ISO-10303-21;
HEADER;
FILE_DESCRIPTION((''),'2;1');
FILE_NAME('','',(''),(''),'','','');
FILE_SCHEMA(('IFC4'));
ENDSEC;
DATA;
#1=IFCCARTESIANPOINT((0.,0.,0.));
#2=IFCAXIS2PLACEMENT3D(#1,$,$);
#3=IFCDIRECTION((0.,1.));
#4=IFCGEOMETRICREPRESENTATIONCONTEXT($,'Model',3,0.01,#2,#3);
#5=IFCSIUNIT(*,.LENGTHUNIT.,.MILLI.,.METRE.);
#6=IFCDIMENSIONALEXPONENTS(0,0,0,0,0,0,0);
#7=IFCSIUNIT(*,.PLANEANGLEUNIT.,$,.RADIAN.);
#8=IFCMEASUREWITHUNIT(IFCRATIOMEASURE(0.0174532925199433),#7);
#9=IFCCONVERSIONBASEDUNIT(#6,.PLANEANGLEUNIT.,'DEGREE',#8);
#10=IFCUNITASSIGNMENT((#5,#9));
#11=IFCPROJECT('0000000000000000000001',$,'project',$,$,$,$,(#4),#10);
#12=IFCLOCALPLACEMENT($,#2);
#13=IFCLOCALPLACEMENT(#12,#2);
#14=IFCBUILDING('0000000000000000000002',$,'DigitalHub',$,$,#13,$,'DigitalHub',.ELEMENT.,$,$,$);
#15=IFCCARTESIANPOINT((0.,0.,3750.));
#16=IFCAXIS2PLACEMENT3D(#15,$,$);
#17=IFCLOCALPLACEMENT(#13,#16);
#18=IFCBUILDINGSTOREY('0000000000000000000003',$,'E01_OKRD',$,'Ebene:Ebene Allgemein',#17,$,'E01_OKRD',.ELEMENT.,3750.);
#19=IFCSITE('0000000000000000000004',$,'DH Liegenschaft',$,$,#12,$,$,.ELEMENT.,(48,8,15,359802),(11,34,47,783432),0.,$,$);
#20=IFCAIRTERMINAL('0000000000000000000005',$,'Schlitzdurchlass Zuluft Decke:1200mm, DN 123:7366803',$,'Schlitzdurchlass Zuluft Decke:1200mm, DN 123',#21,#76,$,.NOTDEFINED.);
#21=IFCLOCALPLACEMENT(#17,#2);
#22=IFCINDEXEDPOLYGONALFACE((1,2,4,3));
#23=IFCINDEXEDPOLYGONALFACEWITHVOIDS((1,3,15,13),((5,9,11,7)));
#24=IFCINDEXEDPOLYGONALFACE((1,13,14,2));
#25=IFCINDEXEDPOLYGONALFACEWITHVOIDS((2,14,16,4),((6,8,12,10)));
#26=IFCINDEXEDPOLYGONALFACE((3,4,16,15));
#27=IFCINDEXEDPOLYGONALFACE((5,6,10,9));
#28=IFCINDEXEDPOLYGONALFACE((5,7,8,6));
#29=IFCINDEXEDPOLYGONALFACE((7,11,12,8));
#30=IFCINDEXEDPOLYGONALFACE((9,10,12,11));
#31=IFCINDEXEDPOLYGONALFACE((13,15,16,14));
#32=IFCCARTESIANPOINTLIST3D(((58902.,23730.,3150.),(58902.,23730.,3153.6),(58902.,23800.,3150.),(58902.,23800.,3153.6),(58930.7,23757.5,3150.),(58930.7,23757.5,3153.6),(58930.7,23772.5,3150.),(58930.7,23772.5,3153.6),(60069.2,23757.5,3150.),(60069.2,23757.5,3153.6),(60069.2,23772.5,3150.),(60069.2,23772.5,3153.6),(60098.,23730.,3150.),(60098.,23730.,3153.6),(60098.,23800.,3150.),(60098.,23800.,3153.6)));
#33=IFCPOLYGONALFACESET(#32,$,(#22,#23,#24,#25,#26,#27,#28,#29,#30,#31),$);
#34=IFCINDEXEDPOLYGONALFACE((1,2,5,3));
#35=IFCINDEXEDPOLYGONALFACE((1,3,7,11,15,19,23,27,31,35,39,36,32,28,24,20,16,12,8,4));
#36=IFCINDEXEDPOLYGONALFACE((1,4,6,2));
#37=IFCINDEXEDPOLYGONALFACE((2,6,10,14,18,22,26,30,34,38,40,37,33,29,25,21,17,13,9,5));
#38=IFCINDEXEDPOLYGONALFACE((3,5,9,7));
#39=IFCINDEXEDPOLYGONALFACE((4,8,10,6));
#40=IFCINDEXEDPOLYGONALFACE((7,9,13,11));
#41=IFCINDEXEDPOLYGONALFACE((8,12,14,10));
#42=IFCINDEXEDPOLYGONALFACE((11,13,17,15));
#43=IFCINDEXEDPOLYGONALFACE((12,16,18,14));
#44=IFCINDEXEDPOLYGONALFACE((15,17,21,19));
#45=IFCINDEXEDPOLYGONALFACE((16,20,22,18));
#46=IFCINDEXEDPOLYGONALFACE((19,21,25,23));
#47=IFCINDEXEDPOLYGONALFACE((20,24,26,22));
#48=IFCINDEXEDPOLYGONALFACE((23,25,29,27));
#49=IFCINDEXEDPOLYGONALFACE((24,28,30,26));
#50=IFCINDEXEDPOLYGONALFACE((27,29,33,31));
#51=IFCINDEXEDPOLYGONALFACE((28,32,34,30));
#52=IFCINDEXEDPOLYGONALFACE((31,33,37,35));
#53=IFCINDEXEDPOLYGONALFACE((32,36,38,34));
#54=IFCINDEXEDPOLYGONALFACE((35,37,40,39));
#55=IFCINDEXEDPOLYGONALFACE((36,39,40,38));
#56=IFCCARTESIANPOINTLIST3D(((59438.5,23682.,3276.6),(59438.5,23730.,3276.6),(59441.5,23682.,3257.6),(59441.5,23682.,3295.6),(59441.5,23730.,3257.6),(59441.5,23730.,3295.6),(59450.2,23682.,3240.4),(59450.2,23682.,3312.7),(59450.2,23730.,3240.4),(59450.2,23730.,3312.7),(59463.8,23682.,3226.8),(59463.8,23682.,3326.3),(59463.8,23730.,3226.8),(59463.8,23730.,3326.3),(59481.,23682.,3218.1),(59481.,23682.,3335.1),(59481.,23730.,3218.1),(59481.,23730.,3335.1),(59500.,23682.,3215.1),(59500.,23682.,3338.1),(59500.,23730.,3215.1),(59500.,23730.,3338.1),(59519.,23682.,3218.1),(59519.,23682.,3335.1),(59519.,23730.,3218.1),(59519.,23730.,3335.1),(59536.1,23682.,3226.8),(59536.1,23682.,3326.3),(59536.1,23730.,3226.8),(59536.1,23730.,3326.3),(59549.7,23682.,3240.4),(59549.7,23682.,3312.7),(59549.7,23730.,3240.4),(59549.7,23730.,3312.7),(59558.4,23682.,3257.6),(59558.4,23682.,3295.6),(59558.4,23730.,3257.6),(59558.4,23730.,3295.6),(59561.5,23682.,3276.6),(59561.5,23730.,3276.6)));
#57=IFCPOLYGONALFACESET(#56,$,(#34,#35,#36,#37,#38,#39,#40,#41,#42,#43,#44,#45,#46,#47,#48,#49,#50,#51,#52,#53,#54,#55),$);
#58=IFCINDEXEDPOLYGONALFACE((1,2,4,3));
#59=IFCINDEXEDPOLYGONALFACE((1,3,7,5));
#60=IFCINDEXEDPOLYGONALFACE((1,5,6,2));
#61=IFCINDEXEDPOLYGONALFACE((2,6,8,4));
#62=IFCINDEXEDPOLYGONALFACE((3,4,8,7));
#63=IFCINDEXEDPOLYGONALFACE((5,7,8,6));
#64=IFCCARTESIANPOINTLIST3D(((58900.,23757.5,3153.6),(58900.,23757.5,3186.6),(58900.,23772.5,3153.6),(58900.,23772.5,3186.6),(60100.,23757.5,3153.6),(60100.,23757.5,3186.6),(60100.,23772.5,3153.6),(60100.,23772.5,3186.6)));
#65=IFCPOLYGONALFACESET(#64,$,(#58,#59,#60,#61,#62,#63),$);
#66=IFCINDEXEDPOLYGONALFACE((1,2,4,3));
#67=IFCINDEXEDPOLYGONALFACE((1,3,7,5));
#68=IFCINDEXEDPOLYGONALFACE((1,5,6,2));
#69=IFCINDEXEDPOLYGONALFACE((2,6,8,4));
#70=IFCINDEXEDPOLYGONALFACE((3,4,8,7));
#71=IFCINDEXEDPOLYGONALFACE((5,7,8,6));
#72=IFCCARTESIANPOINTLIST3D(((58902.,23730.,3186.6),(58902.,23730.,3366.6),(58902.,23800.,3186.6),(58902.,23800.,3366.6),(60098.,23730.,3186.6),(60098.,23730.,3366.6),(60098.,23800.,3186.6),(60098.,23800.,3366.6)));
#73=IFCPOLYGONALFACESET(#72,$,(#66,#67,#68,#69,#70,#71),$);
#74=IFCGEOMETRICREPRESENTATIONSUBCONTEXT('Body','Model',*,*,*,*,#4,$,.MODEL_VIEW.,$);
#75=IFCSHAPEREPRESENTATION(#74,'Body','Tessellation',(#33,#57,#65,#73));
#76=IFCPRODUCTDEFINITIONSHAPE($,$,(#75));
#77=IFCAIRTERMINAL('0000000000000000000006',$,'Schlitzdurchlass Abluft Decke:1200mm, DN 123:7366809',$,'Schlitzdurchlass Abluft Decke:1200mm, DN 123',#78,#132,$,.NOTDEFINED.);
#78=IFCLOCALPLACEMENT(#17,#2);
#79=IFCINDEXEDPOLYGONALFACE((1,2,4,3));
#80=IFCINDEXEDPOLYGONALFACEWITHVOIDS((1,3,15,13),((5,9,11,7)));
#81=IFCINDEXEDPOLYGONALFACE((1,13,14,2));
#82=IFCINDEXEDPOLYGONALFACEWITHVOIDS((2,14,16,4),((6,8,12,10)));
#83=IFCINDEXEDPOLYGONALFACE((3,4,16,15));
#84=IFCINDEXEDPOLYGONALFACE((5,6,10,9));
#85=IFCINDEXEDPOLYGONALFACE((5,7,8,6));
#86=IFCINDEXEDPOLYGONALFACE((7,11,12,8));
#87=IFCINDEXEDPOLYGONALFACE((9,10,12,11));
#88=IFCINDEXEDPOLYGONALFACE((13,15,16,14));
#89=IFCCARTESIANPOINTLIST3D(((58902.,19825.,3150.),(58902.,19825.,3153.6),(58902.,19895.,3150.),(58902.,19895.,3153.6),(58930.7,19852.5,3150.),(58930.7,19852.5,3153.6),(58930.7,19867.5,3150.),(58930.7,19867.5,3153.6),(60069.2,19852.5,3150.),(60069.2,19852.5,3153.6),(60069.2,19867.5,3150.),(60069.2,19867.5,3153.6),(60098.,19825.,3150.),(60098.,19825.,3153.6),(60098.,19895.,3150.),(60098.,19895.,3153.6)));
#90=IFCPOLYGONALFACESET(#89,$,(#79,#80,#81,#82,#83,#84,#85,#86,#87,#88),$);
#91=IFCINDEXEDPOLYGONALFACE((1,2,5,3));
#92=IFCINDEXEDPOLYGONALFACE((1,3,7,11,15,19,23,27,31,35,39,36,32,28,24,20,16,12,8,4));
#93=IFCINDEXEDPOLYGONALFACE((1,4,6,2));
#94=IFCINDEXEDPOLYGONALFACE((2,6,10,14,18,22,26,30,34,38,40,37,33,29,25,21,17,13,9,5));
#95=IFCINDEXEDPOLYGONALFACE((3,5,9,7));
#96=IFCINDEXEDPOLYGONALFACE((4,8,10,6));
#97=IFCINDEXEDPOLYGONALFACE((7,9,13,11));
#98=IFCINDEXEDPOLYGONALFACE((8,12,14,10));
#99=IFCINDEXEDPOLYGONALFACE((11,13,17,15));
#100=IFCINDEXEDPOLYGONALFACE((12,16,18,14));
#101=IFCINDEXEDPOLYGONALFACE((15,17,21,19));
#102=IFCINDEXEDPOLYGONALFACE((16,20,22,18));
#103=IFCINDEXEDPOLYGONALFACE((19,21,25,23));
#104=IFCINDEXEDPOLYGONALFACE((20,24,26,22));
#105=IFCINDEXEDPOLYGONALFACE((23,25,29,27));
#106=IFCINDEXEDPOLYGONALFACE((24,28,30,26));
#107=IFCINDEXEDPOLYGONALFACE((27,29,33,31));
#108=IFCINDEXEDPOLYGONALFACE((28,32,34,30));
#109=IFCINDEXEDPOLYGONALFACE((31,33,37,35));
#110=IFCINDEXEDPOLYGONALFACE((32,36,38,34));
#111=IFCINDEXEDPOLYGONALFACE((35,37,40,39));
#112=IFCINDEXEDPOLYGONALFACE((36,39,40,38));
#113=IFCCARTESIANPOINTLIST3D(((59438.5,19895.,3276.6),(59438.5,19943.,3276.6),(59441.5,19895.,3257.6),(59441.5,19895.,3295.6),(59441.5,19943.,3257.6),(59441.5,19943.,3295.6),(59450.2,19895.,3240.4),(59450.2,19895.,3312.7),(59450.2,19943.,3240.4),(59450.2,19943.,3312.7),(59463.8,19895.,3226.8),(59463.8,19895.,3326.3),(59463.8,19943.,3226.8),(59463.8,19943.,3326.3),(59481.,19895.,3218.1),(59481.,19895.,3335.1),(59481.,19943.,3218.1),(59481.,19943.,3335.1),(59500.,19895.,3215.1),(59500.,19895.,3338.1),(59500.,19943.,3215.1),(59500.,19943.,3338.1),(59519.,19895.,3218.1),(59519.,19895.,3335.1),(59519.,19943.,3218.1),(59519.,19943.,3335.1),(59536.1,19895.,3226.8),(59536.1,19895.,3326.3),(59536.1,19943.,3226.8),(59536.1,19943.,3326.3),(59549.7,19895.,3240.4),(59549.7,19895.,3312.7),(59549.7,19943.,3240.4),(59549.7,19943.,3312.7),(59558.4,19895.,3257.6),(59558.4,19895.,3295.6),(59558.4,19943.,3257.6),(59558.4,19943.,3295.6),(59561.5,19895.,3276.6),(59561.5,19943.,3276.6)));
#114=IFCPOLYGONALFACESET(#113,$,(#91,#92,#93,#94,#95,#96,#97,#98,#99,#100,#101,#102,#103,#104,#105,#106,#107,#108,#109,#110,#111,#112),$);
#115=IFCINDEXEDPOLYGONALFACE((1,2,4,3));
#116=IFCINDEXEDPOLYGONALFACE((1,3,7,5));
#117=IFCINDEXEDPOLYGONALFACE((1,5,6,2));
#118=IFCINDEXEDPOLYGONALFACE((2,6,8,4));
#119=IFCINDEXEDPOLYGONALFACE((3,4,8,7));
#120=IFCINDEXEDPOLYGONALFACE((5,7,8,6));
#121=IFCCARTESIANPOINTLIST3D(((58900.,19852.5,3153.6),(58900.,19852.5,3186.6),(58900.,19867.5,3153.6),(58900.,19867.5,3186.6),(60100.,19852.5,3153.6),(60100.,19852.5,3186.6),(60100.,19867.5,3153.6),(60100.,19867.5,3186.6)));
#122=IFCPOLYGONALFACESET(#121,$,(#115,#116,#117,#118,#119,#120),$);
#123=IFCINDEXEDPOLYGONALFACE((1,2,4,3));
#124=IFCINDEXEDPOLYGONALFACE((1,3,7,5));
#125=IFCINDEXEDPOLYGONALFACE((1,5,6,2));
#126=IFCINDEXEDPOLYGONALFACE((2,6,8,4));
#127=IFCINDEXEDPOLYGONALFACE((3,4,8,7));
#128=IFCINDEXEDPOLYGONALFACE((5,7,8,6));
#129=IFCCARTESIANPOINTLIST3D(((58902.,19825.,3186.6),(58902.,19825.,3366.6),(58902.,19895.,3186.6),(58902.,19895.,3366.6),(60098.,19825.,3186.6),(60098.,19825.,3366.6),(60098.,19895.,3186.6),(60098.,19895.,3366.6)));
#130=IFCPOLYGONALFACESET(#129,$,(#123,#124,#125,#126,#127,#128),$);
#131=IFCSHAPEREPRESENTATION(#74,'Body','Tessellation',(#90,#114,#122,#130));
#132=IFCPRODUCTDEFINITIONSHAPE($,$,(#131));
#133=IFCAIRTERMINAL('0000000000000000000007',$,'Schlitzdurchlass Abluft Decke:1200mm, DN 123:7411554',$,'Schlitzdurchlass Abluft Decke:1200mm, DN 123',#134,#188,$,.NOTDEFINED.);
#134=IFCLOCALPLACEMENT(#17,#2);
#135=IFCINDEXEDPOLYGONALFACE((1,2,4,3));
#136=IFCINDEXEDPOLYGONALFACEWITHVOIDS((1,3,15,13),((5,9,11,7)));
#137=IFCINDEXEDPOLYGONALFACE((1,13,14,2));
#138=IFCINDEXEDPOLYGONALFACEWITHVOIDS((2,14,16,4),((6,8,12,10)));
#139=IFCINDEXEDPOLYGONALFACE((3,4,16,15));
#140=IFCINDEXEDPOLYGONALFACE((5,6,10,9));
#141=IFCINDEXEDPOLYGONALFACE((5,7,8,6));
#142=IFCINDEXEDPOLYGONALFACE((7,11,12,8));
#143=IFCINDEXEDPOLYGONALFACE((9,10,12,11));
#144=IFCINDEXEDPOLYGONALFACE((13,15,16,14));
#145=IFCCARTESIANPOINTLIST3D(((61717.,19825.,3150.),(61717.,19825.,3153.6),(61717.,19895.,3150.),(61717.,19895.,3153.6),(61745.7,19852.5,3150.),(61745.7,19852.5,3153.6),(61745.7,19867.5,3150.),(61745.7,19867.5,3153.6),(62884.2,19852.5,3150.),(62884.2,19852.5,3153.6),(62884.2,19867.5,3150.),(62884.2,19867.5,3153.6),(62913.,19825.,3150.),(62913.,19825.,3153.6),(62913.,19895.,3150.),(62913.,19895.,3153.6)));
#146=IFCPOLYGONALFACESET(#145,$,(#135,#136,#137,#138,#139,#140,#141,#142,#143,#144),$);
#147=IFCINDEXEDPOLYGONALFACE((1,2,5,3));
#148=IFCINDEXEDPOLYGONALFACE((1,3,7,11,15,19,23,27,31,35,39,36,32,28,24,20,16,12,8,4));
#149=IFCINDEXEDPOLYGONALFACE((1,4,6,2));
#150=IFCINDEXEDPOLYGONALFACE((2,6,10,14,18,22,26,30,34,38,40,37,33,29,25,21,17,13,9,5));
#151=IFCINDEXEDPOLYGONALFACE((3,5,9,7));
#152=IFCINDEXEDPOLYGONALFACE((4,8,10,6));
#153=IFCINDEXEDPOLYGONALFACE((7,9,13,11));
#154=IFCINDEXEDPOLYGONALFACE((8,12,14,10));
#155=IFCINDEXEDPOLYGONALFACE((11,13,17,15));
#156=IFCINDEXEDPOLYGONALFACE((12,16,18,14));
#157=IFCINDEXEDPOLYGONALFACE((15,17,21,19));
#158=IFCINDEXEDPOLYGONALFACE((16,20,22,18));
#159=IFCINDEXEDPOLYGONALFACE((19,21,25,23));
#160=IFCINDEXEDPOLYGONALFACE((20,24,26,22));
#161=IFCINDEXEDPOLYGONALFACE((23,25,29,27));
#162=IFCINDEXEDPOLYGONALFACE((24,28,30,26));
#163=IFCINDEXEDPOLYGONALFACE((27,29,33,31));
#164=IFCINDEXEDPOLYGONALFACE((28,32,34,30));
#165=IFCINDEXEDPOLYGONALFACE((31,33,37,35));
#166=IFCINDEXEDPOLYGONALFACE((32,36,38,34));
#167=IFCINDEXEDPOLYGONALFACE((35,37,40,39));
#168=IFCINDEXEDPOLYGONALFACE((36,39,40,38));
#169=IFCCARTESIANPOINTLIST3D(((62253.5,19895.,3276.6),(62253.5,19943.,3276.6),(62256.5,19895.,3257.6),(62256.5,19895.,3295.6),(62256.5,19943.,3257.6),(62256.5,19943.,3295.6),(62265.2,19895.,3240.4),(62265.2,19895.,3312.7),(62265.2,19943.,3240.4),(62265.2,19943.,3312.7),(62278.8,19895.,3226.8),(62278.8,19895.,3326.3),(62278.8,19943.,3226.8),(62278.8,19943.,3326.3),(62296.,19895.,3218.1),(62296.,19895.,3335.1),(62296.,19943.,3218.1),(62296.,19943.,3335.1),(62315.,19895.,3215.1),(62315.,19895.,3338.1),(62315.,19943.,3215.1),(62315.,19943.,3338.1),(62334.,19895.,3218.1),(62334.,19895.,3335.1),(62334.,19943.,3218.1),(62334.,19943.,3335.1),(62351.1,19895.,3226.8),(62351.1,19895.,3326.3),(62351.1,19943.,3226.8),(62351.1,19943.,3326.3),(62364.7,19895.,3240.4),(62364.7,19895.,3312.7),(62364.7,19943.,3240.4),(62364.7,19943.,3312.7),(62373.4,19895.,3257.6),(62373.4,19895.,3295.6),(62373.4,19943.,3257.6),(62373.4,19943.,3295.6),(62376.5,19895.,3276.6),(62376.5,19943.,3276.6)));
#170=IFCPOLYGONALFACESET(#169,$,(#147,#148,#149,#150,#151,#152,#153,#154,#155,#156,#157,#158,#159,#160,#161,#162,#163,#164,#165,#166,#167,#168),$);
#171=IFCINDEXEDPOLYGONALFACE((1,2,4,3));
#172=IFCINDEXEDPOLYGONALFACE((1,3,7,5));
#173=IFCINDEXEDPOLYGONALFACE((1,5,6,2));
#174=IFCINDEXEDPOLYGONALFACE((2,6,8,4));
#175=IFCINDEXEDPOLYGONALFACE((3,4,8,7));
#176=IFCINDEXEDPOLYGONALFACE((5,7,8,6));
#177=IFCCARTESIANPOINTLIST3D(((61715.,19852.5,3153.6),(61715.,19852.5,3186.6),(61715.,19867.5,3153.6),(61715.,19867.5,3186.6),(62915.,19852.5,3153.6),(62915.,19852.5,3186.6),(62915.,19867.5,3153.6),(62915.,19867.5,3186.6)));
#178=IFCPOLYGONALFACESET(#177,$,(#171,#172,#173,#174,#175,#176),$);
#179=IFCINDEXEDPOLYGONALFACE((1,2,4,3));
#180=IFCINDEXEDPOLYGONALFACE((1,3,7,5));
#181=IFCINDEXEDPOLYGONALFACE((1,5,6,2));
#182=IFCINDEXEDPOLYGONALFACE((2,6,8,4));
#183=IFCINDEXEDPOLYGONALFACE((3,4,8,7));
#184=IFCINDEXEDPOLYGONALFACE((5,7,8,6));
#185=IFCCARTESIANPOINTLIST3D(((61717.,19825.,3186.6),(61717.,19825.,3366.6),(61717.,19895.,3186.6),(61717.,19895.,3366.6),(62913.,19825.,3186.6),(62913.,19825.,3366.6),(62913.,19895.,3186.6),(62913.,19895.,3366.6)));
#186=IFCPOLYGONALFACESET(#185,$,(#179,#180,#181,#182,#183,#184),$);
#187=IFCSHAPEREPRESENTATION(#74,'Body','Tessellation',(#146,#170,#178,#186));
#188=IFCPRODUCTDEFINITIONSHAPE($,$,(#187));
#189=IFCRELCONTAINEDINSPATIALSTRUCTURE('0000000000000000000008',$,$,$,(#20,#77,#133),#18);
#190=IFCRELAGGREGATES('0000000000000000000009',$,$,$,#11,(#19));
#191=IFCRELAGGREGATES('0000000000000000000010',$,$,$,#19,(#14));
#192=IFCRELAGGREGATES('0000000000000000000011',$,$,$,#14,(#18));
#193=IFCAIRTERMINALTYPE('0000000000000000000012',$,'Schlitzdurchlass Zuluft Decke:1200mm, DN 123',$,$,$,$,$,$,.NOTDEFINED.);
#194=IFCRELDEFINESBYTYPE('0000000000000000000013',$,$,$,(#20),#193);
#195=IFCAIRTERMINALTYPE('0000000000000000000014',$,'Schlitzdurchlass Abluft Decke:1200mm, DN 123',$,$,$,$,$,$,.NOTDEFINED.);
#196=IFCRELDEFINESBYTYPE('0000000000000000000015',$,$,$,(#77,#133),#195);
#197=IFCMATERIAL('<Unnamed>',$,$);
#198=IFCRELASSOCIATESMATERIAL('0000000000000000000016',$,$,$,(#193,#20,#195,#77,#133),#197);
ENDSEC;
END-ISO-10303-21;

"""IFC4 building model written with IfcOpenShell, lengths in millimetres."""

from ifc_helpers import new_model, entity, si_unit, converted_unit, direction, frame, origin, place, context, subcontext, project, spatial, indexed_curve, outline, extrude, source, transform, mapped, material, type_object, type_shapes, element, save


model = new_model("IFC4")

# Units and contexts
model_context = context("Model", 3, precision=0.01, world=origin(), true_north=direction((0.0, 1.0)))
body_context = subcontext(model_context, "Body", "Model", "MODEL_VIEW")
ifc_project = project(units=[si_unit("LENGTHUNIT", "METRE", prefix="MILLI"), converted_unit("PLANEANGLEUNIT", "DEGREE", entity("IfcRatioMeasure", 0.0174532925199433), si_unit("PLANEANGLEUNIT", "RADIAN"), dimensions=[0, 0, 0, 0, 0, 0, 0])], contexts=[model_context])

# Site, building, storey
site_placement = place(None, origin())
site = spatial("IfcSite", under=ifc_project, at=site_placement, Name="DH Liegenschaft", CompositionType="ELEMENT", RefLatitude=(48, 8, 15, 359802), RefLongitude=(11, 34, 47, 783432), RefElevation=0.0)
building_placement = place(site_placement, origin())
building = spatial("IfcBuilding", under=site, at=building_placement, Name="DigitalHub", LongName="DigitalHub", CompositionType="ELEMENT")
storey_placement = place(building_placement, frame((0.0, 0.0, 3750.0)))
storey = spatial("IfcBuildingStorey", under=building, at=storey_placement, Name="E01_OKRD", ObjectType="Ebene:Ebene Allgemein", LongName="E01_OKRD", CompositionType="ELEMENT", Elevation=3750.0)

# Air terminals
ifc_material_1 = material(Name="<Unnamed>")
air_terminal_type_1 = type_object("IfcAirTerminalType", Name="Schlitzdurchlass Zuluft Decke:1200mm, DN 123", PredefinedType="NOTDEFINED", material=ifc_material_1)
shared_shape_1 = source(origin(), body_context, "Body", "SweptSolid", [
    extrude(outline(indexed_curve([(-598.0, -35.0), (598.0, -35.0), (598.0, 35.0), (-598.0, 35.0), (-598.0, -35.0)], self_intersect=False), holes=[indexed_curve([(-569.2, -7.5), (-569.2, 7.5), (569.2, 7.5), (569.2, -7.5), (-569.2, -7.5)], self_intersect=False)]), frame((600.0, 35.0, 0.0), z_axis=(0.0, 0.0, 1.0), x_axis=(-1.0, 0.0, 0.0)), (0.0, 0.0, 1.0), 3.6),
    extrude(outline(indexed_curve([(61.5, 0.0), (58.5, 19.0), (49.8, 36.1), (36.1, 49.8), (19.0, 58.5), (0.0, 61.5), (-19.0, 58.5), (-36.1, 49.8), (-49.8, 36.1), (-58.5, 19.0), (-61.5, 0.0), (-58.5, -19.0), (-49.8, -36.1), (-36.1, -49.8), (-19.0, -58.5), (0.0, -61.5), (19.0, -58.5), (36.1, -49.8), (49.8, -36.1), (58.5, -19.0), (61.5, 0.0)], self_intersect=False)), frame((600.0, 70.0, 126.6), z_axis=(0.0, 1.0, 0.0), x_axis=(-1.0, 0.0, 0.0)), (0.0, 0.0, 1.0), 48.0),
    extrude(outline(indexed_curve([(-600.0, -7.5), (600.0, -7.5), (600.0, 7.5), (-600.0, 7.5), (-600.0, -7.5)], self_intersect=False)), frame((600.0, 35.0, 3.6), z_axis=(0.0, 0.0, 1.0), x_axis=(-1.0, 0.0, 0.0)), (0.0, 0.0, 1.0), 33.0),
    extrude(outline(indexed_curve([(-598.0, -35.0), (598.0, -35.0), (598.0, 35.0), (-598.0, 35.0), (-598.0, -35.0)], self_intersect=False)), frame((600.0, 35.0, 36.6), z_axis=(0.0, 0.0, 1.0), x_axis=(-1.0, 0.0, 0.0)), (0.0, 0.0, 1.0), 180.0),
])
type_shapes(air_terminal_type_1, [shared_shape_1])
air_terminal_placement = place(storey_placement, frame((60100.0, 23800.0, 3150.0), z_axis=(0.0, 0.0, 1.0), x_axis=(-1.0, 0.0, 0.0)))
element("IfcAirTerminal", 1, at=air_terminal_placement, inside=storey, type_object=air_terminal_type_1, material=ifc_material_1, Name="Schlitzdurchlass Zuluft Decke:1200mm, DN 123:7366803", ObjectType="Schlitzdurchlass Zuluft Decke:1200mm, DN 123", PredefinedType="NOTDEFINED", context=body_context, shape_type="MappedRepresentation", body=[
    mapped(shared_shape_1, transform((0.0, 0.0, 0.0), scale=1.0)),
])
air_terminal_type_2 = type_object("IfcAirTerminalType", Name="Schlitzdurchlass Abluft Decke:1200mm, DN 123", PredefinedType="NOTDEFINED", material=ifc_material_1)
shared_shape_2 = source(origin(), body_context, "Body", "SweptSolid", [
    extrude(outline(indexed_curve([(-598.0, -35.0), (598.0, -35.0), (598.0, 35.0), (-598.0, 35.0), (-598.0, -35.0)], self_intersect=False), holes=[indexed_curve([(-569.2, -7.5), (-569.2, 7.5), (569.2, 7.5), (569.2, -7.5), (-569.2, -7.5)], self_intersect=False)]), frame((0.0, 0.0, 0.0), z_axis=(0.0, 0.0, 1.0), x_axis=(-1.0, 0.0, 0.0)), (0.0, 0.0, 1.0), 3.6),
    extrude(outline(indexed_curve([(61.5, 0.0), (58.5, 19.0), (49.8, 36.1), (36.1, 49.8), (19.0, 58.5), (0.0, 61.5), (-19.0, 58.5), (-36.1, 49.8), (-49.8, 36.1), (-58.5, 19.0), (-61.5, 0.0), (-58.5, -19.0), (-49.8, -36.1), (-36.1, -49.8), (-19.0, -58.5), (0.0, -61.5), (19.0, -58.5), (36.1, -49.8), (49.8, -36.1), (58.5, -19.0), (61.5, 0.0)], self_intersect=False)), frame((0.0, 35.0, 126.6), z_axis=(0.0, 1.0, 0.0), x_axis=(-1.0, 0.0, 0.0)), (0.0, 0.0, 1.0), 48.0),
    extrude(outline(indexed_curve([(-600.0, -7.5), (600.0, -7.5), (600.0, 7.5), (-600.0, 7.5), (-600.0, -7.5)], self_intersect=False)), frame((0.0, 0.0, 3.6), z_axis=(0.0, 0.0, 1.0), x_axis=(-1.0, 0.0, 0.0)), (0.0, 0.0, 1.0), 33.0),
    extrude(outline(indexed_curve([(-598.0, -35.0), (598.0, -35.0), (598.0, 35.0), (-598.0, 35.0), (-598.0, -35.0)], self_intersect=False)), frame((0.0, 0.0, 36.6), z_axis=(0.0, 0.0, 1.0), x_axis=(-1.0, 0.0, 0.0)), (0.0, 0.0, 1.0), 180.0),
])
type_shapes(air_terminal_type_2, [shared_shape_2])
for number, where, name in (
    (2, (59500.0, 19860.0, 3150.0), "Schlitzdurchlass Abluft Decke:1200mm, DN 123:7366809"),
    (3, (62315.0, 19860.0, 3150.0), "Schlitzdurchlass Abluft Decke:1200mm, DN 123:7411554"),
):
    element("IfcAirTerminal", number, at=place(storey_placement, frame(where)), inside=storey, type_object=air_terminal_type_2, material=ifc_material_1, Name=name, ObjectType="Schlitzdurchlass Abluft Decke:1200mm, DN 123", PredefinedType="NOTDEFINED", context=body_context, shape_type="MappedRepresentation", body=[
        mapped(shared_shape_2, transform((0.0, 0.0, 0.0), scale=1.0)),
    ])

save(model, "model.ifc")
